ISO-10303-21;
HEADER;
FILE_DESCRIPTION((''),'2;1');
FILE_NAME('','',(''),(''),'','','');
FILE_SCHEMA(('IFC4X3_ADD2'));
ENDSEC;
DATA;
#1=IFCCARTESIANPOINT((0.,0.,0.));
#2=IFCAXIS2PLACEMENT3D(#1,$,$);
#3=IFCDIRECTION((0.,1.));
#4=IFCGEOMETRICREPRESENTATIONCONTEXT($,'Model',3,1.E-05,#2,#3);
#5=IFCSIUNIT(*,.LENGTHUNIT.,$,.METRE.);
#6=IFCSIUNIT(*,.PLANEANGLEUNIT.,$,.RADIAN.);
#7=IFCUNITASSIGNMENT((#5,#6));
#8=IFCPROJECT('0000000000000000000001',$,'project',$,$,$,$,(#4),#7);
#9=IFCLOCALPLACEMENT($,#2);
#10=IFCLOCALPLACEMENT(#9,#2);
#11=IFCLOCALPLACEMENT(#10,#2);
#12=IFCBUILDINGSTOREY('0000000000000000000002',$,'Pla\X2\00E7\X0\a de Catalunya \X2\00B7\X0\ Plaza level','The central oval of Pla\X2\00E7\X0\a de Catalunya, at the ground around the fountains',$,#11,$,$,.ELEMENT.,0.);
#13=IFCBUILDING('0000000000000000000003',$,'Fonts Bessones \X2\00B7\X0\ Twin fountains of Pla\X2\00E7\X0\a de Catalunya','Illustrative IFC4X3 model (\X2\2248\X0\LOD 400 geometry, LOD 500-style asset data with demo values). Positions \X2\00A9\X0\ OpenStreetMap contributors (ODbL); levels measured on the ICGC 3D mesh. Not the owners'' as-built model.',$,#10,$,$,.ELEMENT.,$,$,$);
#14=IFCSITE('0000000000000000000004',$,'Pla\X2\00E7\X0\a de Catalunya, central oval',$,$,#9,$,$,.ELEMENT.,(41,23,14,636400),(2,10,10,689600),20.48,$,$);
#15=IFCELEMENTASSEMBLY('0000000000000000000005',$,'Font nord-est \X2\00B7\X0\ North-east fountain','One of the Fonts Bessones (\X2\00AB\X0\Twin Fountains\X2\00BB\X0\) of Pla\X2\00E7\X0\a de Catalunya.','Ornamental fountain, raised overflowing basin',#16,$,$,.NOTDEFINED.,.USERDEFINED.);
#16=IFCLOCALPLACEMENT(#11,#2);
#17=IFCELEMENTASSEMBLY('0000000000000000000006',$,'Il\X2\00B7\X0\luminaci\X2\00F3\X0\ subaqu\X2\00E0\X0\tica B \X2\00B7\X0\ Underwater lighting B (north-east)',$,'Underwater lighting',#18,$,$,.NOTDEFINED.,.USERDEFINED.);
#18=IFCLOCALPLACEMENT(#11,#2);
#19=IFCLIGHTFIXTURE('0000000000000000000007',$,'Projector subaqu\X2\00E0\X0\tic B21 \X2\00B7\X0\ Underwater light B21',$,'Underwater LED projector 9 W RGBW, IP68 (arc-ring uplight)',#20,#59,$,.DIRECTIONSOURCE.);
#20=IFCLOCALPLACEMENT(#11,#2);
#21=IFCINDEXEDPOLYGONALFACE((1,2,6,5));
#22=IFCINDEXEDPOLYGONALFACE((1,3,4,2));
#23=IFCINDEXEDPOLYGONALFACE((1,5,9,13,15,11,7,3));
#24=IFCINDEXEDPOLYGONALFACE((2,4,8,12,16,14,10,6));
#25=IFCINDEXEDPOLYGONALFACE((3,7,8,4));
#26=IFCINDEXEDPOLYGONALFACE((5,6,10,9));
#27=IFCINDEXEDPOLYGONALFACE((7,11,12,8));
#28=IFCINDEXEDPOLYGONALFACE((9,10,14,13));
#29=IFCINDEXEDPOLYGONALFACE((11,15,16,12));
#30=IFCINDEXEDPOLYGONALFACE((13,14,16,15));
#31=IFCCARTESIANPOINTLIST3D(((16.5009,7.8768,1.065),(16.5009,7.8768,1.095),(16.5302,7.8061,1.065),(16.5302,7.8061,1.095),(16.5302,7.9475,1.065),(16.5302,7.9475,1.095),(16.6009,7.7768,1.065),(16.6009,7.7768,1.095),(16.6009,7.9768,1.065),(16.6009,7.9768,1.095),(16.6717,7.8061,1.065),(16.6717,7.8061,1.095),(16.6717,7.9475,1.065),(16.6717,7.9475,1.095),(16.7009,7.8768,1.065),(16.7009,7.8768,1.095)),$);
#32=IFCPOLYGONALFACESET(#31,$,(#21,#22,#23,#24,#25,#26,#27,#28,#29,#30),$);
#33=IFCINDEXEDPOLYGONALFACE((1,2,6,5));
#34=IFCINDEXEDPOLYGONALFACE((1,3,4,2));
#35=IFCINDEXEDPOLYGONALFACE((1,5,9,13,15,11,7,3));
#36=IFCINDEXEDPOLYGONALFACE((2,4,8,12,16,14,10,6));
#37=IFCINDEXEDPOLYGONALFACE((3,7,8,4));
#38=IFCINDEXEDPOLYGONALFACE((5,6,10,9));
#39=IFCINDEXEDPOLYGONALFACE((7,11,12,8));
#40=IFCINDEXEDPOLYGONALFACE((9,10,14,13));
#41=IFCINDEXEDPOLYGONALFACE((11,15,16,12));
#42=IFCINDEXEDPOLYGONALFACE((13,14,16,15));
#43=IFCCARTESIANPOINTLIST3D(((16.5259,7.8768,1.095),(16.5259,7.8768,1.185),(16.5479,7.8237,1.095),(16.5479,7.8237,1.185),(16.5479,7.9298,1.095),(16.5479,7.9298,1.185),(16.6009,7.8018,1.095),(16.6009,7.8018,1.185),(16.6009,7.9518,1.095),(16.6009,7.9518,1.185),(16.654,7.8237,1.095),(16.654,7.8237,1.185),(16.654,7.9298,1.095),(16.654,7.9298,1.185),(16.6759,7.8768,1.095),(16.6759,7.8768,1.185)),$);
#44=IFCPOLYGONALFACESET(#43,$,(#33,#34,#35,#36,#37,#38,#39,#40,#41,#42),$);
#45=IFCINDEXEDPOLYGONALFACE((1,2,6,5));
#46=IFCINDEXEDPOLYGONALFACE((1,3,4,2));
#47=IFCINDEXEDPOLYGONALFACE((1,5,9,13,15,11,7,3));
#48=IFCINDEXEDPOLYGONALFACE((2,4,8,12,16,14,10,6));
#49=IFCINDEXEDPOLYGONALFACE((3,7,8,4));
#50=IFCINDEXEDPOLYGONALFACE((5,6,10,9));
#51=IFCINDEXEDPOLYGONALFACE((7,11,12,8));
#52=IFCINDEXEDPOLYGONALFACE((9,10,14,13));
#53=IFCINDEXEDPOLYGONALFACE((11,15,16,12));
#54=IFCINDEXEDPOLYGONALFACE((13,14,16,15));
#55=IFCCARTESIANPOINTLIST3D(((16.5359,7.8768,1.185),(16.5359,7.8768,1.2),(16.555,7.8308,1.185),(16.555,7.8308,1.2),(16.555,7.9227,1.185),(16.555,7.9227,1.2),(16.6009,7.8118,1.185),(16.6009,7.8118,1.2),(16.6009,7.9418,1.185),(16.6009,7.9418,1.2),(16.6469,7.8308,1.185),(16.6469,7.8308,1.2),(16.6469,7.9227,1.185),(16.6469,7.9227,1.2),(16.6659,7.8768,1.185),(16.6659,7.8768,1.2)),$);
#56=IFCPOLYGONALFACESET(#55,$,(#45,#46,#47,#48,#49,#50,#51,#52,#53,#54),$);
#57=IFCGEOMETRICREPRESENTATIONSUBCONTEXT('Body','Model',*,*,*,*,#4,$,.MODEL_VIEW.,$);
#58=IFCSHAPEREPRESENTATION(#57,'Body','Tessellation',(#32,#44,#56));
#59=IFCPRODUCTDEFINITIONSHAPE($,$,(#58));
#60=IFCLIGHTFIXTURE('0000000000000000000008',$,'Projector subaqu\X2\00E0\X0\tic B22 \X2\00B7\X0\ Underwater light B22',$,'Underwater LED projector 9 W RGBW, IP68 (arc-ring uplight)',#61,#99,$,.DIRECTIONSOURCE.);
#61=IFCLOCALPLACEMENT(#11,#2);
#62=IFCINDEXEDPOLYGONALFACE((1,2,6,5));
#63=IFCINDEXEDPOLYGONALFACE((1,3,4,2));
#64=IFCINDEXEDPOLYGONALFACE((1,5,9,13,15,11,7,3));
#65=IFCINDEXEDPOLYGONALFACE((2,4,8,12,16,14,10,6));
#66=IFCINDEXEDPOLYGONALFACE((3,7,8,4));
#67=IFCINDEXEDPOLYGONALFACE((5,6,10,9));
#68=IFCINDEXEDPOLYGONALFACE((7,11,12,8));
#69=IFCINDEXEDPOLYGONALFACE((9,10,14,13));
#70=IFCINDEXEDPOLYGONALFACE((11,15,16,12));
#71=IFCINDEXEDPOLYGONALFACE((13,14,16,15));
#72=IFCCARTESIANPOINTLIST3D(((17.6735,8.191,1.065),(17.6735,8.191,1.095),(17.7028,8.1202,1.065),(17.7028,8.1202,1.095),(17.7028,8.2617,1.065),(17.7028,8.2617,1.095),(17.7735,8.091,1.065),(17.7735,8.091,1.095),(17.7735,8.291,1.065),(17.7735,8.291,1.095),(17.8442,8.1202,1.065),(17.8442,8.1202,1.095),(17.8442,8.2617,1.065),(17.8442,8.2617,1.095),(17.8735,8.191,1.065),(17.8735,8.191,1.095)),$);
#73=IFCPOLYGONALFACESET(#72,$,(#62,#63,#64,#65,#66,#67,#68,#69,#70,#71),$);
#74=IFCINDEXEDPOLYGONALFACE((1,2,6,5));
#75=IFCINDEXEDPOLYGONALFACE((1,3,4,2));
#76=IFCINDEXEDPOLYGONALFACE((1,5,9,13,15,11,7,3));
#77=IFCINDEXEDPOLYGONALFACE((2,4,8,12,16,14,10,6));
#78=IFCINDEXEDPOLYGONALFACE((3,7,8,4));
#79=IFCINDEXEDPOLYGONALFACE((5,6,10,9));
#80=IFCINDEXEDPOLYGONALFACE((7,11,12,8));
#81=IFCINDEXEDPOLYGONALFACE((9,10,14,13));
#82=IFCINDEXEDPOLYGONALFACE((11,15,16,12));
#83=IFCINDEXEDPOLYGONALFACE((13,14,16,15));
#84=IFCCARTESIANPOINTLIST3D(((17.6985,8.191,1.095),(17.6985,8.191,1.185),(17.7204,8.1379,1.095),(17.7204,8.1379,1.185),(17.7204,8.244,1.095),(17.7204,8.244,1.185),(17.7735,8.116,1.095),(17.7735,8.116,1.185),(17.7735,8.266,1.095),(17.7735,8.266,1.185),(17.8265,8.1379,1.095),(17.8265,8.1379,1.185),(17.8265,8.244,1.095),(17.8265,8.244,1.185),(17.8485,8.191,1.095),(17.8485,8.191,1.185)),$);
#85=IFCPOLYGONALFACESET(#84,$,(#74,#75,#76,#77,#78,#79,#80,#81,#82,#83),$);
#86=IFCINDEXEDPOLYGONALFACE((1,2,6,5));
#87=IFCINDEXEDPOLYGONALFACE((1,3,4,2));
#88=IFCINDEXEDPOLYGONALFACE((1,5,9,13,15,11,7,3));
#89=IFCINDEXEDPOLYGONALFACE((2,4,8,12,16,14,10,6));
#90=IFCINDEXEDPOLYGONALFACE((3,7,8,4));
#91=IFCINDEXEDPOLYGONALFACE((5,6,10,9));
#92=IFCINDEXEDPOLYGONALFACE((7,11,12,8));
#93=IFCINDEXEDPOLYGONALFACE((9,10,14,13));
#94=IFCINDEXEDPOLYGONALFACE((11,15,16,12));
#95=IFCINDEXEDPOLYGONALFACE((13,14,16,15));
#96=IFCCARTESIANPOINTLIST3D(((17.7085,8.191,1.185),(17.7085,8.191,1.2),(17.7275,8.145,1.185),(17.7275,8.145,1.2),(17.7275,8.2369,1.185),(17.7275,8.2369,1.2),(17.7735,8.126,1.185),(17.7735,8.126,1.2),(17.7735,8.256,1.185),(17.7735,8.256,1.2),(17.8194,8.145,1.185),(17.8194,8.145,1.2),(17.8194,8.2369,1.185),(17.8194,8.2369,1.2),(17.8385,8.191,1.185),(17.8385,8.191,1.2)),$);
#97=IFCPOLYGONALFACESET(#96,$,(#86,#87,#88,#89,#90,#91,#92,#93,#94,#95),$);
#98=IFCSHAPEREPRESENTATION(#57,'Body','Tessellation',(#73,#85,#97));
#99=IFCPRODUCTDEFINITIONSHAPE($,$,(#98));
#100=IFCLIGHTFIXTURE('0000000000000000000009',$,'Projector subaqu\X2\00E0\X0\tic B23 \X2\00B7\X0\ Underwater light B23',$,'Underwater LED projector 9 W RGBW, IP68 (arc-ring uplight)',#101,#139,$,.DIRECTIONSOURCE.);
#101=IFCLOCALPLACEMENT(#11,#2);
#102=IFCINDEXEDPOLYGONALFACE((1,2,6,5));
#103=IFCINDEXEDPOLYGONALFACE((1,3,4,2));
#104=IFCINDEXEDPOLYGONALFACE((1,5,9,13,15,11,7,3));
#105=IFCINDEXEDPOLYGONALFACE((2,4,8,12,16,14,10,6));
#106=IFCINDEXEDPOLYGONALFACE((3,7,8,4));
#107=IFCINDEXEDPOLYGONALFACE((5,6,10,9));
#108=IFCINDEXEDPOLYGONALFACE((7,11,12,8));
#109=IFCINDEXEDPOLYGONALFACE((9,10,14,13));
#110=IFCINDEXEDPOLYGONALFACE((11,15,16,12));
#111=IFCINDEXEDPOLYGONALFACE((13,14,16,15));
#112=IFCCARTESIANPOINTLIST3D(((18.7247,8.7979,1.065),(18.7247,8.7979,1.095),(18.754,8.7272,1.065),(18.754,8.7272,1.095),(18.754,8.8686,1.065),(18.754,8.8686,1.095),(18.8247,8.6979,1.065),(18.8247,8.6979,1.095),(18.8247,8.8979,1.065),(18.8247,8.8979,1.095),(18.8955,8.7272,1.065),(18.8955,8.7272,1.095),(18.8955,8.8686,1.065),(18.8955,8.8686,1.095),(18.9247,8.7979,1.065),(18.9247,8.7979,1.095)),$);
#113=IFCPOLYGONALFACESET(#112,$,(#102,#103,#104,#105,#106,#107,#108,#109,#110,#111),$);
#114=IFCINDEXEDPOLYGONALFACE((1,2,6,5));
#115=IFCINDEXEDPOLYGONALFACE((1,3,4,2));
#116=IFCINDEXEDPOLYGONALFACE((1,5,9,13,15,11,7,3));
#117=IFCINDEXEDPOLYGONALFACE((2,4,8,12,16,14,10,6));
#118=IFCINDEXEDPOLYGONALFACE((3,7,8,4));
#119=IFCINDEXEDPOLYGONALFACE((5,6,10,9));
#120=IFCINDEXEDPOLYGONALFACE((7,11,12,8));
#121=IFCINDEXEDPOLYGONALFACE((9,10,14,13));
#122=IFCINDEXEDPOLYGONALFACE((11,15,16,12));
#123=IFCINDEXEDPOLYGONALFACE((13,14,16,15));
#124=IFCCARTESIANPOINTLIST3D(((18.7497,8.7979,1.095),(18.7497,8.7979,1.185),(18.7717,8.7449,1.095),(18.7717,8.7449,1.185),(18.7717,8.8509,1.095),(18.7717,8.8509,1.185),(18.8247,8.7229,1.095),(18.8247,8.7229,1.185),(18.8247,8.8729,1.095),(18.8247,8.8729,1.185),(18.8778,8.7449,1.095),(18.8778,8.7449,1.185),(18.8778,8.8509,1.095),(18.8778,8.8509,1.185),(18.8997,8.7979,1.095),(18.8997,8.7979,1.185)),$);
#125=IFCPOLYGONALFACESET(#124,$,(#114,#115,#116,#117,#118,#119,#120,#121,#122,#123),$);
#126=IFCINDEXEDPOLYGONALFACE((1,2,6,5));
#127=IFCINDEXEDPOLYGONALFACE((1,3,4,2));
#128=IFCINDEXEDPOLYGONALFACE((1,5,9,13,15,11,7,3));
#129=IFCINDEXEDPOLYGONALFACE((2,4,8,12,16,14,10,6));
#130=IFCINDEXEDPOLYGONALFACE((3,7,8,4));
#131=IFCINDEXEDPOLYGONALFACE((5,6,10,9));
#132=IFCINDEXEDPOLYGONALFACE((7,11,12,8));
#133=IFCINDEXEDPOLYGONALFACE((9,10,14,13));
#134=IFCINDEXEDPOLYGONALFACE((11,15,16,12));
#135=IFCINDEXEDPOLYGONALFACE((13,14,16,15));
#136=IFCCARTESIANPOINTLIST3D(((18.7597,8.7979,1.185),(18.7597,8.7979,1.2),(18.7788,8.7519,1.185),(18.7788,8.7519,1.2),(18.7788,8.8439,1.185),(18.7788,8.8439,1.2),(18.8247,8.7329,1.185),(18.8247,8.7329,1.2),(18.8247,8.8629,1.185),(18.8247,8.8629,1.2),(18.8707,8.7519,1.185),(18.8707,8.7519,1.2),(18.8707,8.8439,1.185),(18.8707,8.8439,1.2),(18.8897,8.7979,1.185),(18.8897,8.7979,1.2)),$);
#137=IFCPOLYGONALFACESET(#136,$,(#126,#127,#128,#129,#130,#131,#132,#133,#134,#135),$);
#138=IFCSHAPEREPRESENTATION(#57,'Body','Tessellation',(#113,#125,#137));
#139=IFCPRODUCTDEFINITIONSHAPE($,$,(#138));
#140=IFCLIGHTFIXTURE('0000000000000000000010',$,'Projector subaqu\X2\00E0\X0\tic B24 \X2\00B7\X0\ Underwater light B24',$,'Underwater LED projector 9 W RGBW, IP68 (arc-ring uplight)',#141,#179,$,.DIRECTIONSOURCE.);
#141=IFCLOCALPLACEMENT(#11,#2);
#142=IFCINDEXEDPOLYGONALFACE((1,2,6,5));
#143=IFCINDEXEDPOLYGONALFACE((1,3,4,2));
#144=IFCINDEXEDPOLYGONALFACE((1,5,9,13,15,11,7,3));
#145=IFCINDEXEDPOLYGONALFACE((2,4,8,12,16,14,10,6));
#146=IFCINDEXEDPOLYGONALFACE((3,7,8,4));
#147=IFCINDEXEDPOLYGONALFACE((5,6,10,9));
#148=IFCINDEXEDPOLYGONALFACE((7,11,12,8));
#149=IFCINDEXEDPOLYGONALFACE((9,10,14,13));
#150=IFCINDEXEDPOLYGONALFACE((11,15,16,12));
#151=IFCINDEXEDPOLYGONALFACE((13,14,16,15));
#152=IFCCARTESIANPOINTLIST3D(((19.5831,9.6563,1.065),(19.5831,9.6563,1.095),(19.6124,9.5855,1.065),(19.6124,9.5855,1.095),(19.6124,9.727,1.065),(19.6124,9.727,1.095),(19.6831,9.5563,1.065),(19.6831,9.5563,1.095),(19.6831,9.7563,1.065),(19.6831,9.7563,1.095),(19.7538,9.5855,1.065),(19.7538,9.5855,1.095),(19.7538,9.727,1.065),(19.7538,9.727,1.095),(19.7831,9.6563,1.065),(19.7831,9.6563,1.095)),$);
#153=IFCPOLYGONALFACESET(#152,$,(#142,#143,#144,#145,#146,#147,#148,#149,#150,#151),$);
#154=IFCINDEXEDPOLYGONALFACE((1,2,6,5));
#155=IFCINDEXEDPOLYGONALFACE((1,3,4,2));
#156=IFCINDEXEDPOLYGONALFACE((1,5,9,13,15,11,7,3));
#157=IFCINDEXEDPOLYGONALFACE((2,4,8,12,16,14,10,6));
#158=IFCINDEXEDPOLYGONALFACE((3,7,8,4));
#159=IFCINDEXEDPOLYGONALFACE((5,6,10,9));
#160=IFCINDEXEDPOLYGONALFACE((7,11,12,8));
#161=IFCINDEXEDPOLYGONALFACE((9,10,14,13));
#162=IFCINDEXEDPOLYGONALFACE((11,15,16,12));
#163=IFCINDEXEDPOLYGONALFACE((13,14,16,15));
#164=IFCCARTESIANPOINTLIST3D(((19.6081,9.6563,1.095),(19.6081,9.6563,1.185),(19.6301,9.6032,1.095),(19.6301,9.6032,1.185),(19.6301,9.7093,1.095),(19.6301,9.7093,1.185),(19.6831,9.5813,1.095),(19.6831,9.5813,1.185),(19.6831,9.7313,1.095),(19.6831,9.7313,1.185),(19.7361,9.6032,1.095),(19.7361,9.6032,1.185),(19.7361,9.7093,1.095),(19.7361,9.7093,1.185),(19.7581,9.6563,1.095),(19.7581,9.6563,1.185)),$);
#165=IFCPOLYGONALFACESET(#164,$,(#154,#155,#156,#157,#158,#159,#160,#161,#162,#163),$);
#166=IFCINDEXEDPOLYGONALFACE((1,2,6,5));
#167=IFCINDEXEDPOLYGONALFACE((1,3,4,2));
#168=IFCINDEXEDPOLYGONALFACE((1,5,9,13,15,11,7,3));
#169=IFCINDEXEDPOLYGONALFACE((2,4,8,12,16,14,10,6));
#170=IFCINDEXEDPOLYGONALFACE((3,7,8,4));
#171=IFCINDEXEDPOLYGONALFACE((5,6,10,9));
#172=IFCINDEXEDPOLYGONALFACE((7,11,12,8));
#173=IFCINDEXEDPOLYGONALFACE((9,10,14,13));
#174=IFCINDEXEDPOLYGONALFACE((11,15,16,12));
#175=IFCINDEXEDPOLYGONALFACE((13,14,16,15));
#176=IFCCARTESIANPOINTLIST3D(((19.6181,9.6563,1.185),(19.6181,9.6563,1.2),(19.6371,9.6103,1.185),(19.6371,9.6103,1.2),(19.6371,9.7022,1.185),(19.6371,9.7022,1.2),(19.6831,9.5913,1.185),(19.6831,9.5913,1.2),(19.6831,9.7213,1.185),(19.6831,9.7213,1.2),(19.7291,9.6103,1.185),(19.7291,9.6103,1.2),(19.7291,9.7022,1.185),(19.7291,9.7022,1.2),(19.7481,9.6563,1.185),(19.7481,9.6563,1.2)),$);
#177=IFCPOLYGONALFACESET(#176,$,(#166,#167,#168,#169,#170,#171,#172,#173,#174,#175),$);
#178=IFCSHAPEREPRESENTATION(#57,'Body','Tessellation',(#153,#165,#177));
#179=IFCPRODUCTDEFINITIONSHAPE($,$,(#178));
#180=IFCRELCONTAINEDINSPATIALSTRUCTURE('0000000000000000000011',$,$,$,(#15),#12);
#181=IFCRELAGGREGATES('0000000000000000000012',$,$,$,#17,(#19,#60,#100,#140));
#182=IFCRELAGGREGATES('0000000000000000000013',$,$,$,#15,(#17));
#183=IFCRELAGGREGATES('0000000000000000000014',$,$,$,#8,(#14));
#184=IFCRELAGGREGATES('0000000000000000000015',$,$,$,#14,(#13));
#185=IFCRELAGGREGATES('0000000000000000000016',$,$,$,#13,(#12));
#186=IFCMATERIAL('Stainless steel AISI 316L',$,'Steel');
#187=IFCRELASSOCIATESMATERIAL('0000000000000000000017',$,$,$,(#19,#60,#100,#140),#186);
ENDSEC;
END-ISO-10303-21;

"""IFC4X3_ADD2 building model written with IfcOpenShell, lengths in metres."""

from ifc_helpers import new_model, si_unit, direction, frame, origin, place, context, subcontext, project, spatial, polyline, outline, extrude, material, element, aggregate, save


model = new_model("IFC4X3_ADD2")

# Units and contexts
model_context = context("Model", 3, precision=1e-05, world=origin(), true_north=direction((0.0, 1.0)))
body_context = subcontext(model_context, "Body", "Model", "MODEL_VIEW")
ifc_project = project(units=[si_unit("LENGTHUNIT", "METRE"), si_unit("PLANEANGLEUNIT", "RADIAN")], contexts=[model_context])

# Site, building, storey
site_placement = place(None, origin())
site = spatial("IfcSite", under=ifc_project, at=site_placement, Name="Plaça de Catalunya, central oval", CompositionType="ELEMENT", RefLatitude=(41, 23, 14, 636400), RefLongitude=(2, 10, 10, 689600), RefElevation=20.48)
building_placement = place(site_placement, origin())
building = spatial("IfcBuilding", under=site, at=building_placement, Name="Fonts Bessones · Twin fountains of Plaça de Catalunya", Description="Illustrative IFC4X3 model (≈LOD 400 geometry, LOD 500-style asset data with demo values). Positions © OpenStreetMap contributors (ODbL); levels measured on the ICGC 3D mesh. Not the owners' as-built model.", CompositionType="ELEMENT")
storey_placement = place(building_placement, origin())
storey = spatial("IfcBuildingStorey", under=building, at=storey_placement, Name="Plaça de Catalunya · Plaza level", Description="The central oval of Plaça de Catalunya, at the ground around the fountains", CompositionType="ELEMENT", Elevation=0.0)

# Element assemblies, light fixtures
assembly_1_placement = place(building_placement, origin())
assembly_1 = element("IfcElementAssembly", 1, at=assembly_1_placement, inside=storey, Name="Font nord-est · North-east fountain", Description="One of the Fonts Bessones («Twin Fountains») of Plaça de Catalunya.", ObjectType="Ornamental fountain, raised overflowing basin", AssemblyPlace="NOTDEFINED", PredefinedType="USERDEFINED")
assembly_2_placement = place(building_placement, origin())
assembly_2 = element("IfcElementAssembly", 2, at=assembly_2_placement, Name="Il·luminació subaquàtica B · Underwater lighting B (north-east)", ObjectType="Underwater lighting", AssemblyPlace="NOTDEFINED", PredefinedType="USERDEFINED")
ifc_material_1 = material(Name="Stainless steel AISI 316L", Category="Steel")
light_fixture_1_placement = place(building_placement, origin())
light_fixture_1 = element("IfcLightFixture", 3, at=light_fixture_1_placement, material=ifc_material_1, Name="Projector subaquàtic B21 · Underwater light B21", ObjectType="Underwater LED projector 9 W RGBW, IP68 (arc-ring uplight)", PredefinedType="DIRECTIONSOURCE", context=body_context, shape_type="SweptSolid", body=[
    extrude(outline(polyline([(16.7009, 7.8768), (16.6717, 7.9475), (16.6009, 7.9768), (16.5302, 7.9475), (16.5009, 7.8768), (16.5302, 7.8061), (16.6009, 7.7768), (16.6717, 7.8061), (16.7009, 7.8768)])), frame((0.0, 0.0, 1.065)), (0.0, 0.0, 1.0), 0.03),
    extrude(outline(polyline([(16.6759, 7.8768), (16.654, 7.9298), (16.6009, 7.9518), (16.5479, 7.9298), (16.5259, 7.8768), (16.5479, 7.8237), (16.6009, 7.8018), (16.654, 7.8237), (16.6759, 7.8768)])), frame((0.0, 0.0, 1.095)), (0.0, 0.0, 1.0), 0.09),
    extrude(outline(polyline([(16.6659, 7.8768), (16.6469, 7.9227), (16.6009, 7.9418), (16.555, 7.9227), (16.5359, 7.8768), (16.555, 7.8308), (16.6009, 7.8118), (16.6469, 7.8308), (16.6659, 7.8768)])), frame((0.0, 0.0, 1.185)), (0.0, 0.0, 1.0), 0.015),
])
light_fixture_2_placement = place(building_placement, origin())
light_fixture_2 = element("IfcLightFixture", 4, at=light_fixture_2_placement, material=ifc_material_1, Name="Projector subaquàtic B22 · Underwater light B22", ObjectType="Underwater LED projector 9 W RGBW, IP68 (arc-ring uplight)", PredefinedType="DIRECTIONSOURCE", context=body_context, shape_type="SweptSolid", body=[
    extrude(outline(polyline([(17.8735, 8.191), (17.8442, 8.2617), (17.7735, 8.291), (17.7028, 8.2617), (17.6735, 8.191), (17.7028, 8.1202), (17.7735, 8.091), (17.8442, 8.1202), (17.8735, 8.191)])), frame((0.0, 0.0, 1.065)), (0.0, 0.0, 1.0), 0.03),
    extrude(outline(polyline([(17.8485, 8.191), (17.8265, 8.244), (17.7735, 8.266), (17.7204, 8.244), (17.6985, 8.191), (17.7204, 8.1379), (17.7735, 8.116), (17.8265, 8.1379), (17.8485, 8.191)])), frame((0.0, 0.0, 1.095)), (0.0, 0.0, 1.0), 0.09),
    extrude(outline(polyline([(17.8385, 8.191), (17.8194, 8.2369), (17.7735, 8.256), (17.7275, 8.2369), (17.7085, 8.191), (17.7275, 8.145), (17.7735, 8.126), (17.8194, 8.145), (17.8385, 8.191)])), frame((0.0, 0.0, 1.185)), (0.0, 0.0, 1.0), 0.015),
])
light_fixture_3_placement = place(building_placement, origin())
light_fixture_3 = element("IfcLightFixture", 5, at=light_fixture_3_placement, material=ifc_material_1, Name="Projector subaquàtic B23 · Underwater light B23", ObjectType="Underwater LED projector 9 W RGBW, IP68 (arc-ring uplight)", PredefinedType="DIRECTIONSOURCE", context=body_context, shape_type="SweptSolid", body=[
    extrude(outline(polyline([(18.9247, 8.7979), (18.8955, 8.8686), (18.8247, 8.8979), (18.754, 8.8686), (18.7247, 8.7979), (18.754, 8.7272), (18.8247, 8.6979), (18.8955, 8.7272), (18.9247, 8.7979)])), frame((0.0, 0.0, 1.065)), (0.0, 0.0, 1.0), 0.03),
    extrude(outline(polyline([(18.8997, 8.7979), (18.8778, 8.8509), (18.8247, 8.8729), (18.7717, 8.8509), (18.7497, 8.7979), (18.7717, 8.7449), (18.8247, 8.7229), (18.8778, 8.7449), (18.8997, 8.7979)])), frame((0.0, 0.0, 1.095)), (0.0, 0.0, 1.0), 0.09),
    extrude(outline(polyline([(18.8897, 8.7979), (18.8707, 8.8439), (18.8247, 8.8629), (18.7788, 8.8439), (18.7597, 8.7979), (18.7788, 8.7519), (18.8247, 8.7329), (18.8707, 8.7519), (18.8897, 8.7979)])), frame((0.0, 0.0, 1.185)), (0.0, 0.0, 1.0), 0.015),
])
light_fixture_4_placement = place(building_placement, origin())
light_fixture_4 = element("IfcLightFixture", 6, at=light_fixture_4_placement, material=ifc_material_1, Name="Projector subaquàtic B24 · Underwater light B24", ObjectType="Underwater LED projector 9 W RGBW, IP68 (arc-ring uplight)", PredefinedType="DIRECTIONSOURCE", context=body_context, shape_type="SweptSolid", body=[
    extrude(outline(polyline([(19.7831, 9.6563), (19.7538, 9.727), (19.6831, 9.7563), (19.6124, 9.727), (19.5831, 9.6563), (19.6124, 9.5855), (19.6831, 9.5563), (19.7538, 9.5855), (19.7831, 9.6563)])), frame((0.0, 0.0, 1.065)), (0.0, 0.0, 1.0), 0.03),
    extrude(outline(polyline([(19.7581, 9.6563), (19.7361, 9.7093), (19.6831, 9.7313), (19.6301, 9.7093), (19.6081, 9.6563), (19.6301, 9.6032), (19.6831, 9.5813), (19.7361, 9.6032), (19.7581, 9.6563)])), frame((0.0, 0.0, 1.095)), (0.0, 0.0, 1.0), 0.09),
    extrude(outline(polyline([(19.7481, 9.6563), (19.7291, 9.7022), (19.6831, 9.7213), (19.6371, 9.7022), (19.6181, 9.6563), (19.6371, 9.6103), (19.6831, 9.5913), (19.7291, 9.6103), (19.7481, 9.6563)])), frame((0.0, 0.0, 1.185)), (0.0, 0.0, 1.0), 0.015),
])
aggregate(assembly_2, [light_fixture_1, light_fixture_2, light_fixture_3, light_fixture_4])
aggregate(assembly_1, [assembly_2])

save(model, "model.ifc")
